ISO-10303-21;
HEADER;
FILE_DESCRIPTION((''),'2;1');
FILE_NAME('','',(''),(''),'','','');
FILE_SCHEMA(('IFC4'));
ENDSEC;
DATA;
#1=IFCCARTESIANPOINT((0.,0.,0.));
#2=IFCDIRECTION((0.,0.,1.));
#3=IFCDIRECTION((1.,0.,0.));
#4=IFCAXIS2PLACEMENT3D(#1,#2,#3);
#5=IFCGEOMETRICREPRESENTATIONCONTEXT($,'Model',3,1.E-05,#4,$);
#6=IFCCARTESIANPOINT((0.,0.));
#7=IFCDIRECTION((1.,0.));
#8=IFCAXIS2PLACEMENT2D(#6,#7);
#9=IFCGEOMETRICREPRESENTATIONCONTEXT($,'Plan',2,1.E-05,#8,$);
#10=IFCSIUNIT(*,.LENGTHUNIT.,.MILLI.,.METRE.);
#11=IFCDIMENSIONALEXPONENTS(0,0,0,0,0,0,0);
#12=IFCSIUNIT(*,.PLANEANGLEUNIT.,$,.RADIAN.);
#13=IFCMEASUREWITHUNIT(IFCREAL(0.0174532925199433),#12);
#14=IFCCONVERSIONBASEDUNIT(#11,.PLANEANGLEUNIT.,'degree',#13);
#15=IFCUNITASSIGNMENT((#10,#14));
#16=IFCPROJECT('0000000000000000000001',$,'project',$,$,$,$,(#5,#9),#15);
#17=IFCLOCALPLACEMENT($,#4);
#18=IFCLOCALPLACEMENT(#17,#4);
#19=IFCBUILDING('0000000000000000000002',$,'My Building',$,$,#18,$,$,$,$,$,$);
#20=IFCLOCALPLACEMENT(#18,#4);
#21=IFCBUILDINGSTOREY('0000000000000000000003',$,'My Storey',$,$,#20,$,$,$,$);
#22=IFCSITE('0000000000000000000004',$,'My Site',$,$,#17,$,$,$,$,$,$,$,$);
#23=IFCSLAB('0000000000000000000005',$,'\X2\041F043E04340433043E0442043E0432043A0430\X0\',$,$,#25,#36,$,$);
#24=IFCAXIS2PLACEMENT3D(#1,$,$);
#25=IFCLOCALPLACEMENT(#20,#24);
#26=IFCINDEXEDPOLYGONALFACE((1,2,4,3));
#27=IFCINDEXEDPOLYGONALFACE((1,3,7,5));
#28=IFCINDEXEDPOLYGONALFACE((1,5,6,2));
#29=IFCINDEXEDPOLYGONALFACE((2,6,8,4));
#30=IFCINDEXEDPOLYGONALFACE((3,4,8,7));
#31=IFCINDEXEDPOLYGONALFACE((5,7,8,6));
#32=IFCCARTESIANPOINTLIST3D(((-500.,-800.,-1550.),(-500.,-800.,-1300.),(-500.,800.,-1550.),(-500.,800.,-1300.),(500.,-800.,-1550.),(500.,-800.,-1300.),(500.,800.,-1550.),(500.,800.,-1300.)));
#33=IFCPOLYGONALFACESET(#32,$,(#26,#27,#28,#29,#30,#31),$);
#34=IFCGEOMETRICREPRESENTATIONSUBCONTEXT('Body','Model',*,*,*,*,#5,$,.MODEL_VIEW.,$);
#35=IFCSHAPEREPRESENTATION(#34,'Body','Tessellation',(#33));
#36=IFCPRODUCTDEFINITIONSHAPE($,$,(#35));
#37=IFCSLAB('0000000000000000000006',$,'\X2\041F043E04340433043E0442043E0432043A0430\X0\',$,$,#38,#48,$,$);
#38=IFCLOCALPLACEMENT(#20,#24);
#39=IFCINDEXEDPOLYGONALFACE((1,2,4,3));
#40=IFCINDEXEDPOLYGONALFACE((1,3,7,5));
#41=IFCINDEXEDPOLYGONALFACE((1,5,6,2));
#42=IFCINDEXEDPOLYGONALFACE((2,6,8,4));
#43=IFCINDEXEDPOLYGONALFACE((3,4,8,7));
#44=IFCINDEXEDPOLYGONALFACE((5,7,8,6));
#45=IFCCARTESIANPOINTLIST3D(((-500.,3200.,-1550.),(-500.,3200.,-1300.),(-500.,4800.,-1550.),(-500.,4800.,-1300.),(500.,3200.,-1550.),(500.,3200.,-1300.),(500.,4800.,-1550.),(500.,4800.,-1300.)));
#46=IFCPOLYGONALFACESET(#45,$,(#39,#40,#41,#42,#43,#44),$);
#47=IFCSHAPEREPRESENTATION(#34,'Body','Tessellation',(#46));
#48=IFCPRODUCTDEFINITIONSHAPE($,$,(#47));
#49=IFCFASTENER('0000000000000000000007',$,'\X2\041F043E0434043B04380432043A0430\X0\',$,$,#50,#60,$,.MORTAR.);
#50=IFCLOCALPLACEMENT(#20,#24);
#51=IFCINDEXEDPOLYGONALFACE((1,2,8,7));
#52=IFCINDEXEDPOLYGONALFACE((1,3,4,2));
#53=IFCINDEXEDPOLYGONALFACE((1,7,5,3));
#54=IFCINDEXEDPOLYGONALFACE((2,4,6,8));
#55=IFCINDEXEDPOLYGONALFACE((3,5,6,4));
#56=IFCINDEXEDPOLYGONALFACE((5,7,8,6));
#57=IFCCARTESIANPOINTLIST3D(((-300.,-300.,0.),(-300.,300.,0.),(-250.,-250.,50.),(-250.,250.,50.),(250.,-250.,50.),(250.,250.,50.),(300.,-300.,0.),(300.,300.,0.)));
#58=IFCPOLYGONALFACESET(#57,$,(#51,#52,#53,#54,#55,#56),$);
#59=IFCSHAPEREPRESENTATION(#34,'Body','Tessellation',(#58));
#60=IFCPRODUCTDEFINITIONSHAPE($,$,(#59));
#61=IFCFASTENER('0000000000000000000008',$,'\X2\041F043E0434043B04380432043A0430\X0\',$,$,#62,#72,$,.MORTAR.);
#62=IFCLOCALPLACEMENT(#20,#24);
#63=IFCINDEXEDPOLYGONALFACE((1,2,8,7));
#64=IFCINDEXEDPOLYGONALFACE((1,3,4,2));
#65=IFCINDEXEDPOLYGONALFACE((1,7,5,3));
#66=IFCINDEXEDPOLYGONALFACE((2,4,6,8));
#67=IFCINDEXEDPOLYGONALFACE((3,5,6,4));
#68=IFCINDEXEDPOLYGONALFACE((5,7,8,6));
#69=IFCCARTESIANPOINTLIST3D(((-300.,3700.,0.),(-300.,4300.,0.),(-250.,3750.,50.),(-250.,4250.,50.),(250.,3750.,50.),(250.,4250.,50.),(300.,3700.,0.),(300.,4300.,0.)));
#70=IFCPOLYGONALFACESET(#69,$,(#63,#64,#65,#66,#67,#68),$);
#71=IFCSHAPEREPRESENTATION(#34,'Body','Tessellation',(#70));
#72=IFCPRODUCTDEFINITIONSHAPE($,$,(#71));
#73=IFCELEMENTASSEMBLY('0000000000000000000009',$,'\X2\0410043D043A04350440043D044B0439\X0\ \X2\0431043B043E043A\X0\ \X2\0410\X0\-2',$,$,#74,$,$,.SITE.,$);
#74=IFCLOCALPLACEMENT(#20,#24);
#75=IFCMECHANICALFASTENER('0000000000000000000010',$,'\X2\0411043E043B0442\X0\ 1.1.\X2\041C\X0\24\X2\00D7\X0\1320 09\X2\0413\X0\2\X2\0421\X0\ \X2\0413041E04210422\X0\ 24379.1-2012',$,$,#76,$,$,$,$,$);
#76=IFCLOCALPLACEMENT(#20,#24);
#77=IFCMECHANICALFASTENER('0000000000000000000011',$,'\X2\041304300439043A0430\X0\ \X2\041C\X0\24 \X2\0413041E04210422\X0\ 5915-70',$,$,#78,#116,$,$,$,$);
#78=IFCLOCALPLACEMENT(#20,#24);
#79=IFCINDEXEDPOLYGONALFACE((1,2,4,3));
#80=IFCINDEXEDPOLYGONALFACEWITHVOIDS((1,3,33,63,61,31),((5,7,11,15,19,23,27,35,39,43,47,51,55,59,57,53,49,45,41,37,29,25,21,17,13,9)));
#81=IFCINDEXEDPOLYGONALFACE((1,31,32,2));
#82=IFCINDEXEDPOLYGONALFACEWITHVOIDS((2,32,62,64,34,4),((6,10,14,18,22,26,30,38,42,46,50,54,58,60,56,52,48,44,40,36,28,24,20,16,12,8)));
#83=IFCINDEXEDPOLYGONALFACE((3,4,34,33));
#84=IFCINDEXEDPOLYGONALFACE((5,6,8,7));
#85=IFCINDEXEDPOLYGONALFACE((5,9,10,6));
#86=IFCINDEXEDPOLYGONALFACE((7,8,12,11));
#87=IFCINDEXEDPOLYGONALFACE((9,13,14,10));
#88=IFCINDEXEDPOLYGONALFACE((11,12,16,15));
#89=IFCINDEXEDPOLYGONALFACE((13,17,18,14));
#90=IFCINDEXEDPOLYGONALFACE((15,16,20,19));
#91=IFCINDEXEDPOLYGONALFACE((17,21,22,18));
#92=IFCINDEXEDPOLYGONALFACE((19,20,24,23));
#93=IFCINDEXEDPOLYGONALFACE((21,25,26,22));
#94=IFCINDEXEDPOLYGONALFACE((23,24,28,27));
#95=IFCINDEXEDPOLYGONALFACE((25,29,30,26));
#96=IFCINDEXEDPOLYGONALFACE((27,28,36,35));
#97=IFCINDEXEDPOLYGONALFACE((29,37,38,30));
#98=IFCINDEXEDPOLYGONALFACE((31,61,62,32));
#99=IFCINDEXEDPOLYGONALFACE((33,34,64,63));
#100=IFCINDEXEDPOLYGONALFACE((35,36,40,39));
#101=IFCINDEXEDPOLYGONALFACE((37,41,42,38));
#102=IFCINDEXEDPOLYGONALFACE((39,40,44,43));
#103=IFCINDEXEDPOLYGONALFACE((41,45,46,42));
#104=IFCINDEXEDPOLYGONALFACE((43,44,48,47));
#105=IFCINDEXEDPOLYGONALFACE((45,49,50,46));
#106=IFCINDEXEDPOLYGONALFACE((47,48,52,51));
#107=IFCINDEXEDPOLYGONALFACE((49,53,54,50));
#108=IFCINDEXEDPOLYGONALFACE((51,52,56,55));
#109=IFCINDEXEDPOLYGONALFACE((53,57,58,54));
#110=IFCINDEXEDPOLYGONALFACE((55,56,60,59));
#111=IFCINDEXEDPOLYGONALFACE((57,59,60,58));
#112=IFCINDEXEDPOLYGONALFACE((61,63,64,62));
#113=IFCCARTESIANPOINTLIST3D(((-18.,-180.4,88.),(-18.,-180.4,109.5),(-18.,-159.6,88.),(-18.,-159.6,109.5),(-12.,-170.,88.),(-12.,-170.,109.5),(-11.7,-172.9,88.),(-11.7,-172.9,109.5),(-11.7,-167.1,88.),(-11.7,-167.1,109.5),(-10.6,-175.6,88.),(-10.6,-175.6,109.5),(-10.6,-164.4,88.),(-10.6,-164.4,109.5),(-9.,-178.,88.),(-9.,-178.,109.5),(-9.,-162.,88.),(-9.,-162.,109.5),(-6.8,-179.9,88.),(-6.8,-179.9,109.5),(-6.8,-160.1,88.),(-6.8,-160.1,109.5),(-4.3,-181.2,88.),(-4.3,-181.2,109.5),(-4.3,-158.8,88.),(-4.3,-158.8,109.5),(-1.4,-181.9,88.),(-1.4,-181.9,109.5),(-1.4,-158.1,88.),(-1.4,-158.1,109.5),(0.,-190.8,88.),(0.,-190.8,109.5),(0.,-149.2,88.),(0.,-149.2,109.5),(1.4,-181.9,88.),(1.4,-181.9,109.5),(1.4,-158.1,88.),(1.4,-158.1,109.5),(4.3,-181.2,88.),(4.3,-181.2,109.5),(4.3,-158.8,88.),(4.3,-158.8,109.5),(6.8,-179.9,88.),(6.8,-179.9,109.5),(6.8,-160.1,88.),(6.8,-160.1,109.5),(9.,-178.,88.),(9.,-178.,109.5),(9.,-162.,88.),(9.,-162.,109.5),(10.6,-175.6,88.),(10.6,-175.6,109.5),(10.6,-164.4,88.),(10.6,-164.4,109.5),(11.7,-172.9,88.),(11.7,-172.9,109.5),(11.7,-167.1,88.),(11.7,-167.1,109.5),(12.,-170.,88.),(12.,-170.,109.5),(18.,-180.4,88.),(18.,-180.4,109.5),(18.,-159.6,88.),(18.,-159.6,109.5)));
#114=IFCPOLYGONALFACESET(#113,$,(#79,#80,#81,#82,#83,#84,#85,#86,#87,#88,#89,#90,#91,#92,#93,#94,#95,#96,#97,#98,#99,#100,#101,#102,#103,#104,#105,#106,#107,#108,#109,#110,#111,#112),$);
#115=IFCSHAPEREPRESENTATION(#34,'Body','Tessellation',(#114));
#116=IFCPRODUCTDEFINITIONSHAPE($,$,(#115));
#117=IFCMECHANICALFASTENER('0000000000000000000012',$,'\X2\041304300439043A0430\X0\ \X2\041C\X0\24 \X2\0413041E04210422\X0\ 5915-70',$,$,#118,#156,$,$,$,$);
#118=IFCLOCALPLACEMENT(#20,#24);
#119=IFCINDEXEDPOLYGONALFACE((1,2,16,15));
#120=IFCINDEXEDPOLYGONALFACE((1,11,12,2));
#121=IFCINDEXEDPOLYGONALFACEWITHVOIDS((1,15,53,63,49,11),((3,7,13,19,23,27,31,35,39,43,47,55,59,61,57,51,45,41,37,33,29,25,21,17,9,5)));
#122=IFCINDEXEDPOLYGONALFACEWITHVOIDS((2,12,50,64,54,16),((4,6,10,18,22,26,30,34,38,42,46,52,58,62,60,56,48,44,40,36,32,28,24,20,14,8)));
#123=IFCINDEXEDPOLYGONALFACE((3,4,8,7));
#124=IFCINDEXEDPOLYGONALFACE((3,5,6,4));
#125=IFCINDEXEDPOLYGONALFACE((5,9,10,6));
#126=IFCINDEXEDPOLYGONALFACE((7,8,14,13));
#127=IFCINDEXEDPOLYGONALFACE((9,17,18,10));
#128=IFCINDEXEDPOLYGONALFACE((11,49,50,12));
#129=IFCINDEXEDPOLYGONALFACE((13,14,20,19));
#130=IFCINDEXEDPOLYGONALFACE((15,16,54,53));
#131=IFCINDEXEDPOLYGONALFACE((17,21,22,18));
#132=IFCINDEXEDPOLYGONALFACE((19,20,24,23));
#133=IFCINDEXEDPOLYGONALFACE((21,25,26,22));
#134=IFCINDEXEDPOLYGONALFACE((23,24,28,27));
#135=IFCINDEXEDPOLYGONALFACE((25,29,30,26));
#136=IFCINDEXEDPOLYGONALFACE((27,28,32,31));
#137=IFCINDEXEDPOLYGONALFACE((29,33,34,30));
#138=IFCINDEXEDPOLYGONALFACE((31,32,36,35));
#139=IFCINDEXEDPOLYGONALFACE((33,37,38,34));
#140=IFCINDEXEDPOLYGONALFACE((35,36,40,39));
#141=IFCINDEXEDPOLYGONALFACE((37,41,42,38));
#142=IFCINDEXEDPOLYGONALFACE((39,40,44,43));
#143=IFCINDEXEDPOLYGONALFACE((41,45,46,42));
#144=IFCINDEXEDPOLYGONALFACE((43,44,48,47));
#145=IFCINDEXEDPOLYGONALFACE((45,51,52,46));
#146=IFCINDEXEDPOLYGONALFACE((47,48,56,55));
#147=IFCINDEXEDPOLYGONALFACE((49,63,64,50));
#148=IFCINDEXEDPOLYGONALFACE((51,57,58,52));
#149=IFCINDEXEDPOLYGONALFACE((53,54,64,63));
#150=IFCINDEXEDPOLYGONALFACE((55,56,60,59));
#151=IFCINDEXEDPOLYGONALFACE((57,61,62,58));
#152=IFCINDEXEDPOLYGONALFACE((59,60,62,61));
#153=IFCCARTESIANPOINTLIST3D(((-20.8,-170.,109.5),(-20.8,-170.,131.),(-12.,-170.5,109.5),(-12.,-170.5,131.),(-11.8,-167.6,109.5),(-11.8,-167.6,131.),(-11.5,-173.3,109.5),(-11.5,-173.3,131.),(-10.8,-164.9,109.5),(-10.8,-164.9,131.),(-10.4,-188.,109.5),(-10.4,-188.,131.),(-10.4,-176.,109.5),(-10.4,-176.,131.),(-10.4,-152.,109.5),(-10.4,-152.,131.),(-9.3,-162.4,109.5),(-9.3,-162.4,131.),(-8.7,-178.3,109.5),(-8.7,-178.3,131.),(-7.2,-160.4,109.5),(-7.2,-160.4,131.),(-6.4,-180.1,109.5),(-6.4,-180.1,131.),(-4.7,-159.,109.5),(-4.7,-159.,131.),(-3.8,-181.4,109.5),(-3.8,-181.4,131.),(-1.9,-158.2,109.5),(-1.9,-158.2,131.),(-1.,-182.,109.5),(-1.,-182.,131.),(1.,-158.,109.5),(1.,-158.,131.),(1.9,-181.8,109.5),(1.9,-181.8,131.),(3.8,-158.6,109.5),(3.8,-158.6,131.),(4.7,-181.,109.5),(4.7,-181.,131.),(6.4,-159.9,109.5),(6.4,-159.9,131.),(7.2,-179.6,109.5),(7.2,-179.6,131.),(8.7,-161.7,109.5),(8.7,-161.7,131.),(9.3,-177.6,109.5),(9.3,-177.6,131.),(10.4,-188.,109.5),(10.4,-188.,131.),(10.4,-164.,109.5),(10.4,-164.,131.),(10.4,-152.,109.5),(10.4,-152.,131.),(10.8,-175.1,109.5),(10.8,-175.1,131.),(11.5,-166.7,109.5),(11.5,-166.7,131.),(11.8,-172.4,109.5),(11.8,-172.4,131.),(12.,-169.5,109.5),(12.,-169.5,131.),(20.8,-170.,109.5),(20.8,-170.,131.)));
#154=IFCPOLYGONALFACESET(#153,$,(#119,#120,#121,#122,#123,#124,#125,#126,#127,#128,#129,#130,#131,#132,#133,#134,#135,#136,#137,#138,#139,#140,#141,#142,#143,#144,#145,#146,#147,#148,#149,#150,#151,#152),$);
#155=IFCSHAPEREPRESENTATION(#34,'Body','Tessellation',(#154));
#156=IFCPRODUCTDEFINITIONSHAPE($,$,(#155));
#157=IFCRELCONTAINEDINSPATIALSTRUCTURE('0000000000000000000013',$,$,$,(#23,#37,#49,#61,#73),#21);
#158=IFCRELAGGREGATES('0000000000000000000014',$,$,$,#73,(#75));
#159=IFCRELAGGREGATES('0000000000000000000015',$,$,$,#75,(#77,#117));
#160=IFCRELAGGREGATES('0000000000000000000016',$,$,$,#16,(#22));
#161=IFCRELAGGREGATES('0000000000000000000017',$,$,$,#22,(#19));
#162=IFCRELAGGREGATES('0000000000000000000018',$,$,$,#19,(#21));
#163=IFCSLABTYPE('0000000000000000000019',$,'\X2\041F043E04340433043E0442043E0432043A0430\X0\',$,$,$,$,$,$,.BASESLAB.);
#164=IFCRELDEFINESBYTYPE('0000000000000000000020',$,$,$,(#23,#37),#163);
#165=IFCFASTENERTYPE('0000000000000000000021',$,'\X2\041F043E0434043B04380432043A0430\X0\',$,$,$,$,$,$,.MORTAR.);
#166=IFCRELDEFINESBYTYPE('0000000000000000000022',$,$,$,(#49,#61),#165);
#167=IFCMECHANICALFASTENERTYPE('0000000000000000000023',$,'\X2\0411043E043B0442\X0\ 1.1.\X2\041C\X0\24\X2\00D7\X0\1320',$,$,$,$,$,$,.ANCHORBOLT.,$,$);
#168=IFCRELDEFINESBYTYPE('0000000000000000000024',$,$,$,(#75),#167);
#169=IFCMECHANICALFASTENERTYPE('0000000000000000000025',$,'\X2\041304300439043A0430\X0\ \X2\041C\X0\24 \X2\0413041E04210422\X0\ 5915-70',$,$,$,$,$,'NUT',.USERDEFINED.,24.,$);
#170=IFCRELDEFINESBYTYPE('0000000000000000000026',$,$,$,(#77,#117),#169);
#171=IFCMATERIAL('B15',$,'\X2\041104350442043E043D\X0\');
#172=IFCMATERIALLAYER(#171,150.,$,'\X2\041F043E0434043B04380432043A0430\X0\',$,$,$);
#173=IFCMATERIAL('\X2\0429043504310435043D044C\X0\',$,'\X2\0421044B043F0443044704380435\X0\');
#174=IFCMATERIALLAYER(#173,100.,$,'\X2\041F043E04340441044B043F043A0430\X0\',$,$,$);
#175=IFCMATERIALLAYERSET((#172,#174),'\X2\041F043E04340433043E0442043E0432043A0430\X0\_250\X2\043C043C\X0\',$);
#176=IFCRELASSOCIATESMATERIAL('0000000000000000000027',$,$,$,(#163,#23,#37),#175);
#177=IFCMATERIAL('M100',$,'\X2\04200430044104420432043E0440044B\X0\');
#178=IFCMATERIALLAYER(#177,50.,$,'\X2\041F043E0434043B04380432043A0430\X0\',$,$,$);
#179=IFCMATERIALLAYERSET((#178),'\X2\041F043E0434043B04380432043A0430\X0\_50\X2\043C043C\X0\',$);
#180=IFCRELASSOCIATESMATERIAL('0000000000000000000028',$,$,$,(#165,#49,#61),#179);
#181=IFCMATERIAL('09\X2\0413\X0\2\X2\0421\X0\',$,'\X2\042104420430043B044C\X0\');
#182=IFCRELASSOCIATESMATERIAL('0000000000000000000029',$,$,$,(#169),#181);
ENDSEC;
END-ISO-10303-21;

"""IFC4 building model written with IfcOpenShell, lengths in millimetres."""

from ifc_helpers import new_model, entity, si_unit, converted_unit, frame, origin_with_axes, origin_2d_with_axis, place, context, subcontext, project, spatial, polyline, line, indexed_curve, outline, extrude, clip, halfspace, source, transform, mapped, material, layer, layer_set, layer_usage, type_object, type_shapes, element, aggregate, save


model = new_model("IFC4")

# Units and contexts
model_context = context("Model", 3, precision=1e-05, world=origin_with_axes())
plan_context = context("Plan", 2, precision=1e-05, world=origin_2d_with_axis())
body_context = subcontext(model_context, "Body", "Model", "MODEL_VIEW")
ifc_project = project(units=[si_unit("LENGTHUNIT", "METRE", prefix="MILLI"), converted_unit("PLANEANGLEUNIT", "degree", entity("IfcReal", 0.0174532925199433), si_unit("PLANEANGLEUNIT", "RADIAN"), dimensions=[0, 0, 0, 0, 0, 0, 0])], contexts=[model_context, plan_context])

# Site, building, storey
site_placement = place(None, origin_with_axes())
site = spatial("IfcSite", under=ifc_project, at=site_placement, Name="My Site")
building_placement = place(site_placement, origin_with_axes())
building = spatial("IfcBuilding", under=site, at=building_placement, Name="My Building")
storey_placement = place(building_placement, origin_with_axes())
storey = spatial("IfcBuildingStorey", under=building, at=storey_placement, Name="My Storey")

# Slabs
ifc_material_1 = material(Name="B15", Category="Бетон")
ifc_layer_1 = layer(ifc_material_1, 150.0, Name="Подливка")
ifc_material_2 = material(Name="Щебень", Category="Сыпучие")
ifc_layer_2 = layer(ifc_material_2, 100.0, Name="Подсыпка")
ifc_layer_set_1 = layer_set([ifc_layer_1, ifc_layer_2], Name="Подготовка_250мм")
ifc_layer_usage_1 = layer_usage(ifc_layer_set_1, "AXIS3", "NEGATIVE", 0.0)
slab_type = type_object("IfcSlabType", Name="Подготовка", PredefinedType="BASESLAB", material=ifc_layer_set_1)
for number, where, z_axis, x_axis, name in (
    (1, (0.0, 0.0, -1550.0), (0.0, 0.0, 1.0), (1.0, 0.0, 0.0), "Подготовка"),
    (2, (0.0, 4000.0, -1550.0), (0.0, 0.0, 1.0), (1.0, 0.0, 0.0), "Подготовка"),
):
    element("IfcSlab", number, at=place(storey_placement, frame(where, z_axis=z_axis, x_axis=x_axis)), inside=storey, type_object=slab_type, material=ifc_layer_usage_1, Name=name, context=body_context, shape_type="SweptSolid", body=[
        extrude(outline(indexed_curve([(-500.0, -800.0), (500.0, -800.0), (500.0, 800.0), (-500.0, 800.0)], segments=[line(3, 2), line(2, 1), line(1, 4), line(4, 3)], self_intersect=False)), None, (0.0, 0.0, 1.0), 250.0),
    ])

# Fasteners
ifc_material_3 = material(Name="M100", Category="Растворы")
ifc_layer_3 = layer(ifc_material_3, 50.0, Name="Подливка")
ifc_layer_set_2 = layer_set([ifc_layer_3], Name="Подливка_50мм")
ifc_layer_usage_2 = layer_usage(ifc_layer_set_2, "AXIS3", "POSITIVE", 0.0)
fastener_type = type_object("IfcFastenerType", Name="Подливка", PredefinedType="MORTAR", material=ifc_layer_set_2)
placement = place(storey_placement, origin_with_axes())
element("IfcFastener", 3, at=placement, inside=storey, type_object=fastener_type, material=ifc_layer_usage_2, Name="Подливка", PredefinedType="MORTAR", context=body_context, shape_type="Clipping", body=[
    clip(clip(clip(clip(extrude(outline(indexed_curve([(-300.0, -300.0), (300.0, -300.0), (300.0, 300.0), (-300.0, 300.0)], segments=[line(3, 2), line(2, 1), line(1, 4), line(4, 3)], self_intersect=False)), None, (0.0, 0.0, 1.0), 50.0), halfspace(frame((-53.6, 200.0, 353.6), z_axis=(0.707107, 0.0, 0.707107), x_axis=(0.707107, 0.0, -0.707107)), False)), halfspace(frame((-200.0, -53.6, 353.6), z_axis=(0.0, 0.707107, 0.707107), x_axis=(0.0, 0.707107, -0.707107)), False)), halfspace(frame((200.0, 53.6, 353.6), z_axis=(0.0, -0.707107, 0.707107), x_axis=(0.0, -0.707107, -0.707107)), False)), halfspace(frame((53.6, 200.0, 353.6), z_axis=(-0.707107, 0.0, 0.707107), x_axis=(-0.707107, 0.0, -0.707107)), False)),
])
ifc_layer_usage_3 = layer_usage(ifc_layer_set_2, "AXIS3", "POSITIVE", 0.0)
fastener_1_placement = place(storey_placement, frame((0.0, 4000.0, 0.0), z_axis=(0.0, 0.0, 1.0), x_axis=(1.0, 0.0, 0.0)))
element("IfcFastener", 4, at=fastener_1_placement, inside=storey, type_object=fastener_type, material=ifc_layer_usage_3, Name="Подливка", PredefinedType="MORTAR", context=body_context, shape_type="Clipping", body=[
    clip(clip(clip(clip(extrude(outline(indexed_curve([(-300.0, -300.0), (300.0, -300.0), (300.0, 300.0), (-300.0, 300.0)], segments=[line(3, 2), line(2, 1), line(1, 4), line(4, 3)], self_intersect=False)), None, (0.0, 0.0, 1.0), 50.0), halfspace(frame((-53.6, 200.0, 353.6), z_axis=(0.707107, 0.0, 0.707107), x_axis=(0.707107, 0.0, -0.707107)), False)), halfspace(frame((-200.0, -53.6, 353.6), z_axis=(0.0, 0.707107, 0.707107), x_axis=(0.0, 0.707107, -0.707107)), False)), halfspace(frame((200.0, 53.6, 353.6), z_axis=(0.0, -0.707107, 0.707107), x_axis=(0.0, -0.707107, -0.707107)), False)), halfspace(frame((53.6, 200.0, 353.6), z_axis=(-0.707107, 0.0, 0.707107), x_axis=(-0.707107, 0.0, -0.707107)), False)),
])

# Element assembly, mechanical fastener
assembly_1 = element("IfcElementAssembly", 5, at=placement, inside=storey, Name="Анкерный блок А-2", AssemblyPlace="SITE")
mechanical_fastener_type_1 = type_object("IfcMechanicalFastenerType", Name="Болт 1.1.М24×1320", PredefinedType="ANCHORBOLT")
mechanical_fastener_1_placement = place(placement, frame((0.0, -170.0, 0.0), z_axis=(0.0, 0.0, 1.0), x_axis=(1.0, 0.0, 0.0)))
mechanical_fastener_1 = element("IfcMechanicalFastener", 6, at=mechanical_fastener_1_placement, type_object=mechanical_fastener_type_1, Name="Болт 1.1.М24×1320 09Г2С ГОСТ 24379.1-2012")
ifc_material_4 = material(Name="09Г2С", Category="Сталь")
aggregate(assembly_1, [mechanical_fastener_1])

# Mechanical fasteners
mechanical_fastener_type_2 = type_object("IfcMechanicalFastenerType", Name="Гайка М24 ГОСТ 5915-70", ElementType="NUT", NominalDiameter=24.0, PredefinedType="USERDEFINED", material=ifc_material_4)
shared_shape_1 = source(origin_with_axes(), body_context, "Body", "SweptSolid", [
    extrude(outline(polyline([(-10.4, -18.0), (10.4, -18.0), (20.8, 0.0), (10.4, 18.0), (-10.4, 18.0), (-20.8, 0.0), (-10.4, -18.0)]), holes=[polyline([(-8.0, 9.0), (-5.6, 10.6), (-2.9, 11.7), (0.0, 12.0), (2.9, 11.7), (5.6, 10.6), (8.0, 9.0), (9.9, 6.8), (11.2, 4.3), (11.9, 1.4), (11.9, -1.4), (11.2, -4.3), (9.9, -6.8), (8.0, -9.0), (5.6, -10.6), (2.9, -11.7), (0.0, -12.0), (-2.9, -11.7), (-5.6, -10.6), (-8.0, -9.0), (-9.9, -6.8), (-11.2, -4.3), (-11.9, -1.4), (-11.9, 1.4), (-11.2, 4.3), (-9.9, 6.8), (-8.0, 9.0)])]), frame((0.0, 0.0, 0.0), z_axis=(0.0, 0.0, 1.0), x_axis=(0.0, 1.0, 0.0)), (0.0, 0.0, 1.0), 21.5),
])
type_shapes(mechanical_fastener_type_2, [shared_shape_1])
mechanical_fastener_2_placement = place(mechanical_fastener_1_placement, frame((0.0, 0.0, 88.0), z_axis=(0.0, 0.0, 1.0), x_axis=(1.0, 0.0, 0.0)))
mechanical_fastener_2 = element("IfcMechanicalFastener", 7, at=mechanical_fastener_2_placement, type_object=mechanical_fastener_type_2, Name="Гайка М24 ГОСТ 5915-70", context=body_context, shape_type="MappedRepresentation", body=[
    mapped(shared_shape_1, transform((0.0, 0.0, 0.0), x_axis=(1.0, 0.0, 0.0), y_axis=(0.0, 1.0, 0.0), z_axis=(0.0, 0.0, 1.0), scale=1.0)),
])
mechanical_fastener_3_placement = place(mechanical_fastener_1_placement, frame((0.0, 0.0, 109.5), z_axis=(0.0, 0.0, 1.0), x_axis=(0.866025, 0.5, 0.0)))
mechanical_fastener_3 = element("IfcMechanicalFastener", 8, at=mechanical_fastener_3_placement, type_object=mechanical_fastener_type_2, Name="Гайка М24 ГОСТ 5915-70", context=body_context, shape_type="MappedRepresentation", body=[
    mapped(shared_shape_1, transform((0.0, 0.0, 0.0), x_axis=(1.0, 0.0, 0.0), y_axis=(0.0, 1.0, 0.0), z_axis=(0.0, 0.0, 1.0), scale=1.0)),
])
aggregate(mechanical_fastener_1, [mechanical_fastener_2, mechanical_fastener_3])

save(model, "model.ifc")
